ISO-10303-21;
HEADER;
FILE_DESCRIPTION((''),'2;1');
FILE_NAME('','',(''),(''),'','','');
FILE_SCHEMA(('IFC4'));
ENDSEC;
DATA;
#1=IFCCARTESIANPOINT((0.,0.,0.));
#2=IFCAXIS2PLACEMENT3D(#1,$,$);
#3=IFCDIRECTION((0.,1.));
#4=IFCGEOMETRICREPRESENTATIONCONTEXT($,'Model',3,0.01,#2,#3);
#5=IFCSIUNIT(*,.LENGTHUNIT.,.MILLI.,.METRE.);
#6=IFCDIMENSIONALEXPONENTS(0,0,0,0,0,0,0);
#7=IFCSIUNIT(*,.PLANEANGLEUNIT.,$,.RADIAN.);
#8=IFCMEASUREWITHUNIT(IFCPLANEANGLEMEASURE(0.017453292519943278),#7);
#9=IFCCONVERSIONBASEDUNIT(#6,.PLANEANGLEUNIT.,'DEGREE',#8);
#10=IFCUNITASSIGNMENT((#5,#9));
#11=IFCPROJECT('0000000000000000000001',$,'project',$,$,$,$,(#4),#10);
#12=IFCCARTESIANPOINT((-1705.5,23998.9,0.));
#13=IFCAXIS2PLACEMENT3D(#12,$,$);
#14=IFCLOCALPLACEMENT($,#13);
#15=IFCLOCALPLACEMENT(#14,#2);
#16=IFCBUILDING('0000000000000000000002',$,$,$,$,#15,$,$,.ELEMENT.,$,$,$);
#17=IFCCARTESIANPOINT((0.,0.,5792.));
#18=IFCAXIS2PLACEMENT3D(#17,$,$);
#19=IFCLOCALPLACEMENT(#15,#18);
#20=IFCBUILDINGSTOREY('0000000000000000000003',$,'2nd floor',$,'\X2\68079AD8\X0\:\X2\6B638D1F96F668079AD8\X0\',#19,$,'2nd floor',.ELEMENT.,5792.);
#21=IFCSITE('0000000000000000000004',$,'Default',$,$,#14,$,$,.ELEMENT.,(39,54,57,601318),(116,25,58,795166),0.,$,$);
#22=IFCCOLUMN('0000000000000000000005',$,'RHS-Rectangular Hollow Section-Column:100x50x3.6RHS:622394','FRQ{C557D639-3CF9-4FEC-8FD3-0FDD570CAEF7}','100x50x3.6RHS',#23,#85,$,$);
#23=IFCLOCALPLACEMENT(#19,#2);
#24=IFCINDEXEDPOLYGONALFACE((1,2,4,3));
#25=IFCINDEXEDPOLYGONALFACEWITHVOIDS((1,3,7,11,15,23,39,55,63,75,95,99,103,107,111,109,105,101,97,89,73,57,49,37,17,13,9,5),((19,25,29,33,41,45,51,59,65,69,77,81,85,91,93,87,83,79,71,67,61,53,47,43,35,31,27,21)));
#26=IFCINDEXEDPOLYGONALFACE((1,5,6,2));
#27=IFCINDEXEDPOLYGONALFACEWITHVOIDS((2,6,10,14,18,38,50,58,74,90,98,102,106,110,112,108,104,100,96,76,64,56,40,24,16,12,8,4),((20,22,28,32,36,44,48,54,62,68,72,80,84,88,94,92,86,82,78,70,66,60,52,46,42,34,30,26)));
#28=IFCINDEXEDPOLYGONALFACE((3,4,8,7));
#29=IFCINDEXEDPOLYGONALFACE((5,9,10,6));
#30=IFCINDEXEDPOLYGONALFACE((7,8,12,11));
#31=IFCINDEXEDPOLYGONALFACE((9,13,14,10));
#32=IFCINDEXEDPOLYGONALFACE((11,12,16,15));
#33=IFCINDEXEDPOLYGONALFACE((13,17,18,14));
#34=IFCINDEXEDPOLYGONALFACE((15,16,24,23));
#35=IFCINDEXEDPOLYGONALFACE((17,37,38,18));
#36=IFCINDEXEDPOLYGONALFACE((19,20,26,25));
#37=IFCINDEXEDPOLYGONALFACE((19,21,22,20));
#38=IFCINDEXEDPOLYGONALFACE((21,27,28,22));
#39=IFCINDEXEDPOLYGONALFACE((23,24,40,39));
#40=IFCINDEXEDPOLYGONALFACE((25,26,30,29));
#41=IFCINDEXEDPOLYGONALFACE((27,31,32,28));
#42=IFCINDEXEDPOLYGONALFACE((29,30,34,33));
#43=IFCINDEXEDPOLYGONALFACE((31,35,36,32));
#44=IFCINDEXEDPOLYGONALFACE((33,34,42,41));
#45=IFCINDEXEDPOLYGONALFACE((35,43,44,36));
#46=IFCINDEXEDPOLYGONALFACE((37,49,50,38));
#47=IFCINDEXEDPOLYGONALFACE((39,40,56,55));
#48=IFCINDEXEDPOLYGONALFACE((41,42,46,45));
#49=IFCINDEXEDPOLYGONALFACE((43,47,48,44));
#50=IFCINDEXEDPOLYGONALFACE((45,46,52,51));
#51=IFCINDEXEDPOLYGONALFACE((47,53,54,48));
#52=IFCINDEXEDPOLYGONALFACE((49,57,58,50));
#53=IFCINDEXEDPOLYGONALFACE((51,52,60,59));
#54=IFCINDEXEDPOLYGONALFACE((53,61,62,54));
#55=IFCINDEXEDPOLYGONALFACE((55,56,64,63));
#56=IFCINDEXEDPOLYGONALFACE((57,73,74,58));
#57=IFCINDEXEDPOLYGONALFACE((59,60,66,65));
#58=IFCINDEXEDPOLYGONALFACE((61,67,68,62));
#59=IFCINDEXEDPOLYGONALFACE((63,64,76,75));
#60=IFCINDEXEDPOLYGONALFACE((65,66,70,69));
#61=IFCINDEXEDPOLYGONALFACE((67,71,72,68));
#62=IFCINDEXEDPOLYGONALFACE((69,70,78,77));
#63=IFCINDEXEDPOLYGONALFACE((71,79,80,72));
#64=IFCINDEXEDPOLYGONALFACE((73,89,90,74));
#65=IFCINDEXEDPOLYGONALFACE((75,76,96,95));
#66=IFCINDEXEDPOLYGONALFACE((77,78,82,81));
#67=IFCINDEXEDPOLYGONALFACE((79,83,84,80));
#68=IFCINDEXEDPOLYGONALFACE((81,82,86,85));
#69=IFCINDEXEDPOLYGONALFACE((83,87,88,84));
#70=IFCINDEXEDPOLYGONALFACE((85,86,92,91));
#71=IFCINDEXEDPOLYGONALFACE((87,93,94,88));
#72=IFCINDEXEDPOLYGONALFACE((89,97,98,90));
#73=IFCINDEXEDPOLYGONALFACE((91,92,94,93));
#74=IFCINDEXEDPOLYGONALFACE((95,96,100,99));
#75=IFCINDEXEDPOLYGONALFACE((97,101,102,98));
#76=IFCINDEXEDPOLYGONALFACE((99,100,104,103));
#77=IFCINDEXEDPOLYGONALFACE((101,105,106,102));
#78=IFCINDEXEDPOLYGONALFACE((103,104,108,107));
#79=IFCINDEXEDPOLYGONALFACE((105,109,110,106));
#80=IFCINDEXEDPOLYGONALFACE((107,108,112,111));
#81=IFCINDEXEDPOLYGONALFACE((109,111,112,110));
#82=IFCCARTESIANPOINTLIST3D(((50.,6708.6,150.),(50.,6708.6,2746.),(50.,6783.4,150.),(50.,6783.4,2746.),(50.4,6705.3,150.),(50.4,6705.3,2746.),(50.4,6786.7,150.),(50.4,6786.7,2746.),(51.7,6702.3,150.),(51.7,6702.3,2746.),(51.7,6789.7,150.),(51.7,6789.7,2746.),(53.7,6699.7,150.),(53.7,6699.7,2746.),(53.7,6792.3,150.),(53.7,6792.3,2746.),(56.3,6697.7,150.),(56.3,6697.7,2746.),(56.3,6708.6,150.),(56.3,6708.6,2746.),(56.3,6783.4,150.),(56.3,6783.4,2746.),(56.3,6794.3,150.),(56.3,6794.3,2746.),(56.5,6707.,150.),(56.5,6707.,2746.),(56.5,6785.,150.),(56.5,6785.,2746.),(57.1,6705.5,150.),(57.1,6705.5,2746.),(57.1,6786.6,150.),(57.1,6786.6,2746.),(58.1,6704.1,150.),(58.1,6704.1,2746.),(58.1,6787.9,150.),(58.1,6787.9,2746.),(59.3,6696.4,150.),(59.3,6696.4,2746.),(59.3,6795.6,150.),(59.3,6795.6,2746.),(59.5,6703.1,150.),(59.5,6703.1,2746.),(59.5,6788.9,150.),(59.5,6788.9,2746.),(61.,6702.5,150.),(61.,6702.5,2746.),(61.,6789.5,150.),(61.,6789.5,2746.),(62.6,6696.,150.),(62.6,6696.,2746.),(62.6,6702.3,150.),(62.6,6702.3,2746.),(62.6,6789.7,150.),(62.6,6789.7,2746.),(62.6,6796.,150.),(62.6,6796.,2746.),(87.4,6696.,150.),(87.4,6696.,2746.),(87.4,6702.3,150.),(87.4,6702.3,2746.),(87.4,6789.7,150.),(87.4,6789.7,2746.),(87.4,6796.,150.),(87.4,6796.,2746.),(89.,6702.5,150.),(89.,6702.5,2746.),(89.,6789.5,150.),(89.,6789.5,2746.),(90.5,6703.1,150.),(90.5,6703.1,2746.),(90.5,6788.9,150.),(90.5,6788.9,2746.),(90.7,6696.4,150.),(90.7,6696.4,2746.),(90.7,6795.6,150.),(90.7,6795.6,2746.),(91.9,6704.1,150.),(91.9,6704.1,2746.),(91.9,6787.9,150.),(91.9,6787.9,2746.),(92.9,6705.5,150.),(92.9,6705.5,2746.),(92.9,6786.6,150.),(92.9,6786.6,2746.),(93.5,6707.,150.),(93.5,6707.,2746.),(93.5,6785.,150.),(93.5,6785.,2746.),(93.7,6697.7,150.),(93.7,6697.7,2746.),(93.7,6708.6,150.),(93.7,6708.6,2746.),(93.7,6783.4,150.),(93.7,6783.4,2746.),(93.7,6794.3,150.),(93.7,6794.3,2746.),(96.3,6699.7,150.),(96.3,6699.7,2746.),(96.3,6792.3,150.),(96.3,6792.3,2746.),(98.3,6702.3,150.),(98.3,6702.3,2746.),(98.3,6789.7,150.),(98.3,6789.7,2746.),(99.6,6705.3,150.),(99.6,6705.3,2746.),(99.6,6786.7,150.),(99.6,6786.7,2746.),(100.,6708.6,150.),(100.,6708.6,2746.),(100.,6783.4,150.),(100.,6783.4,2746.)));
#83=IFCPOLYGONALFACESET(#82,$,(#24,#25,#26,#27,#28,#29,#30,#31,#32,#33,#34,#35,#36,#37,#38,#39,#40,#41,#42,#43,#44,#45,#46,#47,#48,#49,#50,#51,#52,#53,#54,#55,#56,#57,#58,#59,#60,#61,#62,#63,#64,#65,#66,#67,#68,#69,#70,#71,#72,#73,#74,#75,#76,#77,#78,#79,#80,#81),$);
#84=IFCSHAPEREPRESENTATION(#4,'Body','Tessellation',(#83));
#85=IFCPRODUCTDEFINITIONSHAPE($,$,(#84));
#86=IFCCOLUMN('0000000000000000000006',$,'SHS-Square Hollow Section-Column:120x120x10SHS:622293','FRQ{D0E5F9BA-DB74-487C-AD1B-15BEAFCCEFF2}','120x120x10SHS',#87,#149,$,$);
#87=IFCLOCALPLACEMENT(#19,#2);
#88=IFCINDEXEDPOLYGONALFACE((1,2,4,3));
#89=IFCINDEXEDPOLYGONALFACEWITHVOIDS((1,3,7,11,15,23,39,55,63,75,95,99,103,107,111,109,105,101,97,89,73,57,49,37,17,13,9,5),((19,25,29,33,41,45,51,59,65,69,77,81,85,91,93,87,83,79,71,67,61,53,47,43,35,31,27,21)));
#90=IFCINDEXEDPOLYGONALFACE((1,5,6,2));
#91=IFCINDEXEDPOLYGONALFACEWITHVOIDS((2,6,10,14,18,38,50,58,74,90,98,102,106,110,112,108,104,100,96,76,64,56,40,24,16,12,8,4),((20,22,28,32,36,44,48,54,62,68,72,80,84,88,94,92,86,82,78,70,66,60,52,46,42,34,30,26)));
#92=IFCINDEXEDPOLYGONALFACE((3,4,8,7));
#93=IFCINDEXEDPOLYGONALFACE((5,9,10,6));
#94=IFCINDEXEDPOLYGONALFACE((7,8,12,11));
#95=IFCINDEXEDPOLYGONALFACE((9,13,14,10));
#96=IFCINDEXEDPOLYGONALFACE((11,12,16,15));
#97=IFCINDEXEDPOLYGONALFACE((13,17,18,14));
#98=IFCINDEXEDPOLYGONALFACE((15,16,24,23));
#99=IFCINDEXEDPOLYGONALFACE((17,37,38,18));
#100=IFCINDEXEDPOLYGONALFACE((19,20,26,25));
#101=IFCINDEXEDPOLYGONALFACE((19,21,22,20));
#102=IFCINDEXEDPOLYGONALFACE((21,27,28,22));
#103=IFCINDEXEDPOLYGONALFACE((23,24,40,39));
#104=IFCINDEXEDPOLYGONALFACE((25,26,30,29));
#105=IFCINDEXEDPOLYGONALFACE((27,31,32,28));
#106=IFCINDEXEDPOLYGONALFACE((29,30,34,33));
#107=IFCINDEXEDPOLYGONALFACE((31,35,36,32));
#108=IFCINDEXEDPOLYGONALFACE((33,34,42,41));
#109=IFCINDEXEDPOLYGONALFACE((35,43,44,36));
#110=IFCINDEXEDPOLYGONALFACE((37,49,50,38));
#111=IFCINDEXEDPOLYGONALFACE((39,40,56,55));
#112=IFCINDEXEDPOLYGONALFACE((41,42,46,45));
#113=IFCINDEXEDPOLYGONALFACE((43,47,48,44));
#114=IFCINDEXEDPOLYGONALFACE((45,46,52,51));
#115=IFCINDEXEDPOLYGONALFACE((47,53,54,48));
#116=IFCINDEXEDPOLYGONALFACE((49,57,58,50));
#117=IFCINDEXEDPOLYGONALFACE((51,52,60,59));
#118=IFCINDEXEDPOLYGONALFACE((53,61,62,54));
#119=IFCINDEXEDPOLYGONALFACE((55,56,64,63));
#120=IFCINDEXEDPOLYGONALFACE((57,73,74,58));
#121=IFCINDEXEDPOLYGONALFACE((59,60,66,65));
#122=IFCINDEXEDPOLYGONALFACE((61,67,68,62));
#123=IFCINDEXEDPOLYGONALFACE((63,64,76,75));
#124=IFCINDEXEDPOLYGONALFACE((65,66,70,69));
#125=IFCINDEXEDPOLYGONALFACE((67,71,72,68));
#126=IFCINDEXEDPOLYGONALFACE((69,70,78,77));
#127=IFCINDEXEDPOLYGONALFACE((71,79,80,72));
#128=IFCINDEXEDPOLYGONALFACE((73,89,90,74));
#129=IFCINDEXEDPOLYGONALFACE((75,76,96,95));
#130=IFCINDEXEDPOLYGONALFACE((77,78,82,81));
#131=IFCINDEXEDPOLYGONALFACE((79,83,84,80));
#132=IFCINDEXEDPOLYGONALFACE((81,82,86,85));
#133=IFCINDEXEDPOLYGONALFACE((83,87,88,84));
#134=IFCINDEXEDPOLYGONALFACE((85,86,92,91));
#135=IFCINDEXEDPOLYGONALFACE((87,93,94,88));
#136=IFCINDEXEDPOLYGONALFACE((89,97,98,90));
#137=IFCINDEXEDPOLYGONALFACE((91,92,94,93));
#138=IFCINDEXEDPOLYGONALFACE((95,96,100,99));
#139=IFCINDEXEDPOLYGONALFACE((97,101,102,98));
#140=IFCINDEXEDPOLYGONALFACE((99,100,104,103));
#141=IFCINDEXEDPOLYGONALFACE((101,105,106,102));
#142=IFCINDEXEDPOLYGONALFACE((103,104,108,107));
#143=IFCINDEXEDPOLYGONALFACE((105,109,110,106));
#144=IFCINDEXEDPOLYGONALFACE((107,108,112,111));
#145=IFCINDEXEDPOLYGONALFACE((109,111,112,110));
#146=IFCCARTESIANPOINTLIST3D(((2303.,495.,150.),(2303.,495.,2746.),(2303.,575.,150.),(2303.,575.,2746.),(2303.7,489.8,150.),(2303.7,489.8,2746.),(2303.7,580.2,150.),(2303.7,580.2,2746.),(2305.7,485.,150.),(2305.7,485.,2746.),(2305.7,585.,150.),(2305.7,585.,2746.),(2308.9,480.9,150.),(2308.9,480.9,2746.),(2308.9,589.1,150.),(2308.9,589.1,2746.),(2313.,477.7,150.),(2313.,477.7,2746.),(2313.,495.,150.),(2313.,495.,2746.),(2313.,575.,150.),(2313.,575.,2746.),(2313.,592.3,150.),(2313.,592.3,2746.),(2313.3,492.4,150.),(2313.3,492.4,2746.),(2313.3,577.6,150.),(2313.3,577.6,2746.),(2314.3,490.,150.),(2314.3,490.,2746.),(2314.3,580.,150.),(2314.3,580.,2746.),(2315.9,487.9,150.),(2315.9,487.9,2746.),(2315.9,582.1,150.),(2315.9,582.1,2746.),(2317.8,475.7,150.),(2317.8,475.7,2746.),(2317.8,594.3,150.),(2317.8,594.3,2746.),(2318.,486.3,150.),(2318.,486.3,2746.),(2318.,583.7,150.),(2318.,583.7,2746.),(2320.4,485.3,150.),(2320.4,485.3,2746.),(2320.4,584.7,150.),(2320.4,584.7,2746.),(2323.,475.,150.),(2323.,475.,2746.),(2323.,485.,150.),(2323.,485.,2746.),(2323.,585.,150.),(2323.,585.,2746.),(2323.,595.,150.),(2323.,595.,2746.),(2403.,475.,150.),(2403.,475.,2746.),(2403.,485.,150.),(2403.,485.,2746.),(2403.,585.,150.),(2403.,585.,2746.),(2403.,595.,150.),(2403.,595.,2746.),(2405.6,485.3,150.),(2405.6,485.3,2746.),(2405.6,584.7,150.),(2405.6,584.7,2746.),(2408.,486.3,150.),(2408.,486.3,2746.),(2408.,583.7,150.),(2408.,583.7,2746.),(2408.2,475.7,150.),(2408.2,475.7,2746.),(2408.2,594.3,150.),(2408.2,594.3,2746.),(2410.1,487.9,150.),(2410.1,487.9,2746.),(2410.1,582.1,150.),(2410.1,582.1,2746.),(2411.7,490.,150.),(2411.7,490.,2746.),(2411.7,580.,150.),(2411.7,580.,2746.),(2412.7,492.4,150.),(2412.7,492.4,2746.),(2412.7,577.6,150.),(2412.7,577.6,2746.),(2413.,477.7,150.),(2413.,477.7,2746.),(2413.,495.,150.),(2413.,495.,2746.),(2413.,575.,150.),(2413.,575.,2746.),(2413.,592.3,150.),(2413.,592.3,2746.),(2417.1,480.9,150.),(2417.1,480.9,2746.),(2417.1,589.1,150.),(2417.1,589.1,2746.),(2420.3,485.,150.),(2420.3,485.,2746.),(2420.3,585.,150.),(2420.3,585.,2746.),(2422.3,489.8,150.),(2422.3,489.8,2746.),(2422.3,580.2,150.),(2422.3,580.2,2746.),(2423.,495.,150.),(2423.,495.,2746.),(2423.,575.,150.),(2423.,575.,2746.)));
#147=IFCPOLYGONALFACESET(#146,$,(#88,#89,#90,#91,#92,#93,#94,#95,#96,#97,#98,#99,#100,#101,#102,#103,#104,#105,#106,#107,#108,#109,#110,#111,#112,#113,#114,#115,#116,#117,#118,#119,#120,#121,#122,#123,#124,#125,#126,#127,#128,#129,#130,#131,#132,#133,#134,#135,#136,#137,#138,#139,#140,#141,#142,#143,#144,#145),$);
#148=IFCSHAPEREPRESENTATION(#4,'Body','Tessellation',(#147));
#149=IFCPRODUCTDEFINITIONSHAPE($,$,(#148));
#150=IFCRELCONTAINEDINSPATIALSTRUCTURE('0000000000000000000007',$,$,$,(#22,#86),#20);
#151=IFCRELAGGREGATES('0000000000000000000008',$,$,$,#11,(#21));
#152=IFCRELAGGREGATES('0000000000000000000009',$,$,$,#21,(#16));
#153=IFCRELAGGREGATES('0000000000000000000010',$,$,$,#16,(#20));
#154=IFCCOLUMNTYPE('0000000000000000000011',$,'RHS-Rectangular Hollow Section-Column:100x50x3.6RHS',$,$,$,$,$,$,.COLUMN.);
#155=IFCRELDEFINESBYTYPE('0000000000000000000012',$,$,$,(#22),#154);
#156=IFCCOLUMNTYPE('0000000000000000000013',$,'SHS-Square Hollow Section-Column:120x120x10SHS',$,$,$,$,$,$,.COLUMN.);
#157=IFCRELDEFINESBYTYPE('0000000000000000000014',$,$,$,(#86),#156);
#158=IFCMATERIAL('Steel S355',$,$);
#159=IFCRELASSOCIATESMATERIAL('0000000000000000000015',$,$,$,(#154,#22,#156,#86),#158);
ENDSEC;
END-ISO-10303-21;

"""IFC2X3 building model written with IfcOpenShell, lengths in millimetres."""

from ifc_helpers import new_model, entity, si_unit, converted_unit, direction, frame, origin, origin_2d, place, context, project, spatial, hollow_rectangle, extrude, clip, halfspace, material, type_object, element, save


model = new_model("IFC2X3")

# Units and contexts
model_context = context("Model", 3, precision=0.01, world=origin(), true_north=direction((0.0, 1.0)))
ifc_project = project(units=[si_unit("LENGTHUNIT", "METRE", prefix="MILLI"), converted_unit("PLANEANGLEUNIT", "DEGREE", entity("IfcPlaneAngleMeasure", 0.017453292519943278), si_unit("PLANEANGLEUNIT", "RADIAN"), dimensions=[0, 0, 0, 0, 0, 0, 0])], contexts=[model_context])

# Site, building, storey
site_placement = place(None, frame((-1705.5, 23998.9, 0.0)))
site = spatial("IfcSite", under=ifc_project, at=site_placement, Name="Default", CompositionType="ELEMENT", RefLatitude=(39, 54, 57, 601318), RefLongitude=(116, 25, 58, 795166), RefElevation=0.0)
building_placement = place(site_placement, origin())
building = spatial("IfcBuilding", under=site, at=building_placement, CompositionType="ELEMENT")
storey_placement = place(building_placement, frame((0.0, 0.0, 5792.0)))
storey = spatial("IfcBuildingStorey", under=building, at=storey_placement, Name="2nd floor", ObjectType="标高:正负零标高", LongName="2nd floor", CompositionType="ELEMENT", Elevation=5792.0)

# Columns
ifc_material_1 = material(Name="Steel S355")
column_type_1 = type_object("IfcColumnType", Name="RHS-Rectangular Hollow Section-Column:100x50x3.6RHS", PredefinedType="COLUMN", material=ifc_material_1)
column_1_placement = place(storey_placement, frame((75.0, 6746.0, 2746.0), z_axis=(0.0, 0.0, 1.0), x_axis=(-1.0, 0.0, 0.0)))
element("IfcColumn", 1, at=column_1_placement, inside=storey, type_object=column_type_1, material=ifc_material_1, Name="RHS-Rectangular Hollow Section-Column:100x50x3.6RHS:622394", Description="FRQ{C557D639-3CF9-4FEC-8FD3-0FDD570CAEF7}", ObjectType="100x50x3.6RHS", context=model_context, shape_type="Clipping", body=[
    clip(extrude(hollow_rectangle(XDim=50.0, YDim=100.0, WallThickness=6.3, InnerFilletRadius=6.3, OuterFilletRadius=12.6, at=origin_2d()), origin(), (0.0, 0.0, -1.0), 2651.9), halfspace(frame((75.0, 6746.0, -2596.0), z_axis=(0.0, 0.0, 1.0), x_axis=(-1.0, 0.0, 0.0)), True)),
])
column_type_2 = type_object("IfcColumnType", Name="SHS-Square Hollow Section-Column:120x120x10SHS", PredefinedType="COLUMN", material=ifc_material_1)
column_2_placement = place(storey_placement, frame((2363.0, 535.0, 2746.0), z_axis=(0.0, 0.0, 1.0), x_axis=(0.0, -1.0, 0.0)))
element("IfcColumn", 2, at=column_2_placement, inside=storey, type_object=column_type_2, material=ifc_material_1, Name="SHS-Square Hollow Section-Column:120x120x10SHS:622293", Description="FRQ{D0E5F9BA-DB74-487C-AD1B-15BEAFCCEFF2}", ObjectType="120x120x10SHS", context=model_context, shape_type="Clipping", body=[
    clip(extrude(hollow_rectangle(XDim=120.0, YDim=120.0, WallThickness=10.0, InnerFilletRadius=10.0, OuterFilletRadius=20.0, at=origin_2d()), origin(), (0.0, 0.0, -1.0), 2680.9), halfspace(frame((535.0, -2363.0, -2596.0), z_axis=(0.0, 0.0, 1.0), x_axis=(0.0, 1.0, 0.0)), True)),
])

save(model, "model.ifc")
